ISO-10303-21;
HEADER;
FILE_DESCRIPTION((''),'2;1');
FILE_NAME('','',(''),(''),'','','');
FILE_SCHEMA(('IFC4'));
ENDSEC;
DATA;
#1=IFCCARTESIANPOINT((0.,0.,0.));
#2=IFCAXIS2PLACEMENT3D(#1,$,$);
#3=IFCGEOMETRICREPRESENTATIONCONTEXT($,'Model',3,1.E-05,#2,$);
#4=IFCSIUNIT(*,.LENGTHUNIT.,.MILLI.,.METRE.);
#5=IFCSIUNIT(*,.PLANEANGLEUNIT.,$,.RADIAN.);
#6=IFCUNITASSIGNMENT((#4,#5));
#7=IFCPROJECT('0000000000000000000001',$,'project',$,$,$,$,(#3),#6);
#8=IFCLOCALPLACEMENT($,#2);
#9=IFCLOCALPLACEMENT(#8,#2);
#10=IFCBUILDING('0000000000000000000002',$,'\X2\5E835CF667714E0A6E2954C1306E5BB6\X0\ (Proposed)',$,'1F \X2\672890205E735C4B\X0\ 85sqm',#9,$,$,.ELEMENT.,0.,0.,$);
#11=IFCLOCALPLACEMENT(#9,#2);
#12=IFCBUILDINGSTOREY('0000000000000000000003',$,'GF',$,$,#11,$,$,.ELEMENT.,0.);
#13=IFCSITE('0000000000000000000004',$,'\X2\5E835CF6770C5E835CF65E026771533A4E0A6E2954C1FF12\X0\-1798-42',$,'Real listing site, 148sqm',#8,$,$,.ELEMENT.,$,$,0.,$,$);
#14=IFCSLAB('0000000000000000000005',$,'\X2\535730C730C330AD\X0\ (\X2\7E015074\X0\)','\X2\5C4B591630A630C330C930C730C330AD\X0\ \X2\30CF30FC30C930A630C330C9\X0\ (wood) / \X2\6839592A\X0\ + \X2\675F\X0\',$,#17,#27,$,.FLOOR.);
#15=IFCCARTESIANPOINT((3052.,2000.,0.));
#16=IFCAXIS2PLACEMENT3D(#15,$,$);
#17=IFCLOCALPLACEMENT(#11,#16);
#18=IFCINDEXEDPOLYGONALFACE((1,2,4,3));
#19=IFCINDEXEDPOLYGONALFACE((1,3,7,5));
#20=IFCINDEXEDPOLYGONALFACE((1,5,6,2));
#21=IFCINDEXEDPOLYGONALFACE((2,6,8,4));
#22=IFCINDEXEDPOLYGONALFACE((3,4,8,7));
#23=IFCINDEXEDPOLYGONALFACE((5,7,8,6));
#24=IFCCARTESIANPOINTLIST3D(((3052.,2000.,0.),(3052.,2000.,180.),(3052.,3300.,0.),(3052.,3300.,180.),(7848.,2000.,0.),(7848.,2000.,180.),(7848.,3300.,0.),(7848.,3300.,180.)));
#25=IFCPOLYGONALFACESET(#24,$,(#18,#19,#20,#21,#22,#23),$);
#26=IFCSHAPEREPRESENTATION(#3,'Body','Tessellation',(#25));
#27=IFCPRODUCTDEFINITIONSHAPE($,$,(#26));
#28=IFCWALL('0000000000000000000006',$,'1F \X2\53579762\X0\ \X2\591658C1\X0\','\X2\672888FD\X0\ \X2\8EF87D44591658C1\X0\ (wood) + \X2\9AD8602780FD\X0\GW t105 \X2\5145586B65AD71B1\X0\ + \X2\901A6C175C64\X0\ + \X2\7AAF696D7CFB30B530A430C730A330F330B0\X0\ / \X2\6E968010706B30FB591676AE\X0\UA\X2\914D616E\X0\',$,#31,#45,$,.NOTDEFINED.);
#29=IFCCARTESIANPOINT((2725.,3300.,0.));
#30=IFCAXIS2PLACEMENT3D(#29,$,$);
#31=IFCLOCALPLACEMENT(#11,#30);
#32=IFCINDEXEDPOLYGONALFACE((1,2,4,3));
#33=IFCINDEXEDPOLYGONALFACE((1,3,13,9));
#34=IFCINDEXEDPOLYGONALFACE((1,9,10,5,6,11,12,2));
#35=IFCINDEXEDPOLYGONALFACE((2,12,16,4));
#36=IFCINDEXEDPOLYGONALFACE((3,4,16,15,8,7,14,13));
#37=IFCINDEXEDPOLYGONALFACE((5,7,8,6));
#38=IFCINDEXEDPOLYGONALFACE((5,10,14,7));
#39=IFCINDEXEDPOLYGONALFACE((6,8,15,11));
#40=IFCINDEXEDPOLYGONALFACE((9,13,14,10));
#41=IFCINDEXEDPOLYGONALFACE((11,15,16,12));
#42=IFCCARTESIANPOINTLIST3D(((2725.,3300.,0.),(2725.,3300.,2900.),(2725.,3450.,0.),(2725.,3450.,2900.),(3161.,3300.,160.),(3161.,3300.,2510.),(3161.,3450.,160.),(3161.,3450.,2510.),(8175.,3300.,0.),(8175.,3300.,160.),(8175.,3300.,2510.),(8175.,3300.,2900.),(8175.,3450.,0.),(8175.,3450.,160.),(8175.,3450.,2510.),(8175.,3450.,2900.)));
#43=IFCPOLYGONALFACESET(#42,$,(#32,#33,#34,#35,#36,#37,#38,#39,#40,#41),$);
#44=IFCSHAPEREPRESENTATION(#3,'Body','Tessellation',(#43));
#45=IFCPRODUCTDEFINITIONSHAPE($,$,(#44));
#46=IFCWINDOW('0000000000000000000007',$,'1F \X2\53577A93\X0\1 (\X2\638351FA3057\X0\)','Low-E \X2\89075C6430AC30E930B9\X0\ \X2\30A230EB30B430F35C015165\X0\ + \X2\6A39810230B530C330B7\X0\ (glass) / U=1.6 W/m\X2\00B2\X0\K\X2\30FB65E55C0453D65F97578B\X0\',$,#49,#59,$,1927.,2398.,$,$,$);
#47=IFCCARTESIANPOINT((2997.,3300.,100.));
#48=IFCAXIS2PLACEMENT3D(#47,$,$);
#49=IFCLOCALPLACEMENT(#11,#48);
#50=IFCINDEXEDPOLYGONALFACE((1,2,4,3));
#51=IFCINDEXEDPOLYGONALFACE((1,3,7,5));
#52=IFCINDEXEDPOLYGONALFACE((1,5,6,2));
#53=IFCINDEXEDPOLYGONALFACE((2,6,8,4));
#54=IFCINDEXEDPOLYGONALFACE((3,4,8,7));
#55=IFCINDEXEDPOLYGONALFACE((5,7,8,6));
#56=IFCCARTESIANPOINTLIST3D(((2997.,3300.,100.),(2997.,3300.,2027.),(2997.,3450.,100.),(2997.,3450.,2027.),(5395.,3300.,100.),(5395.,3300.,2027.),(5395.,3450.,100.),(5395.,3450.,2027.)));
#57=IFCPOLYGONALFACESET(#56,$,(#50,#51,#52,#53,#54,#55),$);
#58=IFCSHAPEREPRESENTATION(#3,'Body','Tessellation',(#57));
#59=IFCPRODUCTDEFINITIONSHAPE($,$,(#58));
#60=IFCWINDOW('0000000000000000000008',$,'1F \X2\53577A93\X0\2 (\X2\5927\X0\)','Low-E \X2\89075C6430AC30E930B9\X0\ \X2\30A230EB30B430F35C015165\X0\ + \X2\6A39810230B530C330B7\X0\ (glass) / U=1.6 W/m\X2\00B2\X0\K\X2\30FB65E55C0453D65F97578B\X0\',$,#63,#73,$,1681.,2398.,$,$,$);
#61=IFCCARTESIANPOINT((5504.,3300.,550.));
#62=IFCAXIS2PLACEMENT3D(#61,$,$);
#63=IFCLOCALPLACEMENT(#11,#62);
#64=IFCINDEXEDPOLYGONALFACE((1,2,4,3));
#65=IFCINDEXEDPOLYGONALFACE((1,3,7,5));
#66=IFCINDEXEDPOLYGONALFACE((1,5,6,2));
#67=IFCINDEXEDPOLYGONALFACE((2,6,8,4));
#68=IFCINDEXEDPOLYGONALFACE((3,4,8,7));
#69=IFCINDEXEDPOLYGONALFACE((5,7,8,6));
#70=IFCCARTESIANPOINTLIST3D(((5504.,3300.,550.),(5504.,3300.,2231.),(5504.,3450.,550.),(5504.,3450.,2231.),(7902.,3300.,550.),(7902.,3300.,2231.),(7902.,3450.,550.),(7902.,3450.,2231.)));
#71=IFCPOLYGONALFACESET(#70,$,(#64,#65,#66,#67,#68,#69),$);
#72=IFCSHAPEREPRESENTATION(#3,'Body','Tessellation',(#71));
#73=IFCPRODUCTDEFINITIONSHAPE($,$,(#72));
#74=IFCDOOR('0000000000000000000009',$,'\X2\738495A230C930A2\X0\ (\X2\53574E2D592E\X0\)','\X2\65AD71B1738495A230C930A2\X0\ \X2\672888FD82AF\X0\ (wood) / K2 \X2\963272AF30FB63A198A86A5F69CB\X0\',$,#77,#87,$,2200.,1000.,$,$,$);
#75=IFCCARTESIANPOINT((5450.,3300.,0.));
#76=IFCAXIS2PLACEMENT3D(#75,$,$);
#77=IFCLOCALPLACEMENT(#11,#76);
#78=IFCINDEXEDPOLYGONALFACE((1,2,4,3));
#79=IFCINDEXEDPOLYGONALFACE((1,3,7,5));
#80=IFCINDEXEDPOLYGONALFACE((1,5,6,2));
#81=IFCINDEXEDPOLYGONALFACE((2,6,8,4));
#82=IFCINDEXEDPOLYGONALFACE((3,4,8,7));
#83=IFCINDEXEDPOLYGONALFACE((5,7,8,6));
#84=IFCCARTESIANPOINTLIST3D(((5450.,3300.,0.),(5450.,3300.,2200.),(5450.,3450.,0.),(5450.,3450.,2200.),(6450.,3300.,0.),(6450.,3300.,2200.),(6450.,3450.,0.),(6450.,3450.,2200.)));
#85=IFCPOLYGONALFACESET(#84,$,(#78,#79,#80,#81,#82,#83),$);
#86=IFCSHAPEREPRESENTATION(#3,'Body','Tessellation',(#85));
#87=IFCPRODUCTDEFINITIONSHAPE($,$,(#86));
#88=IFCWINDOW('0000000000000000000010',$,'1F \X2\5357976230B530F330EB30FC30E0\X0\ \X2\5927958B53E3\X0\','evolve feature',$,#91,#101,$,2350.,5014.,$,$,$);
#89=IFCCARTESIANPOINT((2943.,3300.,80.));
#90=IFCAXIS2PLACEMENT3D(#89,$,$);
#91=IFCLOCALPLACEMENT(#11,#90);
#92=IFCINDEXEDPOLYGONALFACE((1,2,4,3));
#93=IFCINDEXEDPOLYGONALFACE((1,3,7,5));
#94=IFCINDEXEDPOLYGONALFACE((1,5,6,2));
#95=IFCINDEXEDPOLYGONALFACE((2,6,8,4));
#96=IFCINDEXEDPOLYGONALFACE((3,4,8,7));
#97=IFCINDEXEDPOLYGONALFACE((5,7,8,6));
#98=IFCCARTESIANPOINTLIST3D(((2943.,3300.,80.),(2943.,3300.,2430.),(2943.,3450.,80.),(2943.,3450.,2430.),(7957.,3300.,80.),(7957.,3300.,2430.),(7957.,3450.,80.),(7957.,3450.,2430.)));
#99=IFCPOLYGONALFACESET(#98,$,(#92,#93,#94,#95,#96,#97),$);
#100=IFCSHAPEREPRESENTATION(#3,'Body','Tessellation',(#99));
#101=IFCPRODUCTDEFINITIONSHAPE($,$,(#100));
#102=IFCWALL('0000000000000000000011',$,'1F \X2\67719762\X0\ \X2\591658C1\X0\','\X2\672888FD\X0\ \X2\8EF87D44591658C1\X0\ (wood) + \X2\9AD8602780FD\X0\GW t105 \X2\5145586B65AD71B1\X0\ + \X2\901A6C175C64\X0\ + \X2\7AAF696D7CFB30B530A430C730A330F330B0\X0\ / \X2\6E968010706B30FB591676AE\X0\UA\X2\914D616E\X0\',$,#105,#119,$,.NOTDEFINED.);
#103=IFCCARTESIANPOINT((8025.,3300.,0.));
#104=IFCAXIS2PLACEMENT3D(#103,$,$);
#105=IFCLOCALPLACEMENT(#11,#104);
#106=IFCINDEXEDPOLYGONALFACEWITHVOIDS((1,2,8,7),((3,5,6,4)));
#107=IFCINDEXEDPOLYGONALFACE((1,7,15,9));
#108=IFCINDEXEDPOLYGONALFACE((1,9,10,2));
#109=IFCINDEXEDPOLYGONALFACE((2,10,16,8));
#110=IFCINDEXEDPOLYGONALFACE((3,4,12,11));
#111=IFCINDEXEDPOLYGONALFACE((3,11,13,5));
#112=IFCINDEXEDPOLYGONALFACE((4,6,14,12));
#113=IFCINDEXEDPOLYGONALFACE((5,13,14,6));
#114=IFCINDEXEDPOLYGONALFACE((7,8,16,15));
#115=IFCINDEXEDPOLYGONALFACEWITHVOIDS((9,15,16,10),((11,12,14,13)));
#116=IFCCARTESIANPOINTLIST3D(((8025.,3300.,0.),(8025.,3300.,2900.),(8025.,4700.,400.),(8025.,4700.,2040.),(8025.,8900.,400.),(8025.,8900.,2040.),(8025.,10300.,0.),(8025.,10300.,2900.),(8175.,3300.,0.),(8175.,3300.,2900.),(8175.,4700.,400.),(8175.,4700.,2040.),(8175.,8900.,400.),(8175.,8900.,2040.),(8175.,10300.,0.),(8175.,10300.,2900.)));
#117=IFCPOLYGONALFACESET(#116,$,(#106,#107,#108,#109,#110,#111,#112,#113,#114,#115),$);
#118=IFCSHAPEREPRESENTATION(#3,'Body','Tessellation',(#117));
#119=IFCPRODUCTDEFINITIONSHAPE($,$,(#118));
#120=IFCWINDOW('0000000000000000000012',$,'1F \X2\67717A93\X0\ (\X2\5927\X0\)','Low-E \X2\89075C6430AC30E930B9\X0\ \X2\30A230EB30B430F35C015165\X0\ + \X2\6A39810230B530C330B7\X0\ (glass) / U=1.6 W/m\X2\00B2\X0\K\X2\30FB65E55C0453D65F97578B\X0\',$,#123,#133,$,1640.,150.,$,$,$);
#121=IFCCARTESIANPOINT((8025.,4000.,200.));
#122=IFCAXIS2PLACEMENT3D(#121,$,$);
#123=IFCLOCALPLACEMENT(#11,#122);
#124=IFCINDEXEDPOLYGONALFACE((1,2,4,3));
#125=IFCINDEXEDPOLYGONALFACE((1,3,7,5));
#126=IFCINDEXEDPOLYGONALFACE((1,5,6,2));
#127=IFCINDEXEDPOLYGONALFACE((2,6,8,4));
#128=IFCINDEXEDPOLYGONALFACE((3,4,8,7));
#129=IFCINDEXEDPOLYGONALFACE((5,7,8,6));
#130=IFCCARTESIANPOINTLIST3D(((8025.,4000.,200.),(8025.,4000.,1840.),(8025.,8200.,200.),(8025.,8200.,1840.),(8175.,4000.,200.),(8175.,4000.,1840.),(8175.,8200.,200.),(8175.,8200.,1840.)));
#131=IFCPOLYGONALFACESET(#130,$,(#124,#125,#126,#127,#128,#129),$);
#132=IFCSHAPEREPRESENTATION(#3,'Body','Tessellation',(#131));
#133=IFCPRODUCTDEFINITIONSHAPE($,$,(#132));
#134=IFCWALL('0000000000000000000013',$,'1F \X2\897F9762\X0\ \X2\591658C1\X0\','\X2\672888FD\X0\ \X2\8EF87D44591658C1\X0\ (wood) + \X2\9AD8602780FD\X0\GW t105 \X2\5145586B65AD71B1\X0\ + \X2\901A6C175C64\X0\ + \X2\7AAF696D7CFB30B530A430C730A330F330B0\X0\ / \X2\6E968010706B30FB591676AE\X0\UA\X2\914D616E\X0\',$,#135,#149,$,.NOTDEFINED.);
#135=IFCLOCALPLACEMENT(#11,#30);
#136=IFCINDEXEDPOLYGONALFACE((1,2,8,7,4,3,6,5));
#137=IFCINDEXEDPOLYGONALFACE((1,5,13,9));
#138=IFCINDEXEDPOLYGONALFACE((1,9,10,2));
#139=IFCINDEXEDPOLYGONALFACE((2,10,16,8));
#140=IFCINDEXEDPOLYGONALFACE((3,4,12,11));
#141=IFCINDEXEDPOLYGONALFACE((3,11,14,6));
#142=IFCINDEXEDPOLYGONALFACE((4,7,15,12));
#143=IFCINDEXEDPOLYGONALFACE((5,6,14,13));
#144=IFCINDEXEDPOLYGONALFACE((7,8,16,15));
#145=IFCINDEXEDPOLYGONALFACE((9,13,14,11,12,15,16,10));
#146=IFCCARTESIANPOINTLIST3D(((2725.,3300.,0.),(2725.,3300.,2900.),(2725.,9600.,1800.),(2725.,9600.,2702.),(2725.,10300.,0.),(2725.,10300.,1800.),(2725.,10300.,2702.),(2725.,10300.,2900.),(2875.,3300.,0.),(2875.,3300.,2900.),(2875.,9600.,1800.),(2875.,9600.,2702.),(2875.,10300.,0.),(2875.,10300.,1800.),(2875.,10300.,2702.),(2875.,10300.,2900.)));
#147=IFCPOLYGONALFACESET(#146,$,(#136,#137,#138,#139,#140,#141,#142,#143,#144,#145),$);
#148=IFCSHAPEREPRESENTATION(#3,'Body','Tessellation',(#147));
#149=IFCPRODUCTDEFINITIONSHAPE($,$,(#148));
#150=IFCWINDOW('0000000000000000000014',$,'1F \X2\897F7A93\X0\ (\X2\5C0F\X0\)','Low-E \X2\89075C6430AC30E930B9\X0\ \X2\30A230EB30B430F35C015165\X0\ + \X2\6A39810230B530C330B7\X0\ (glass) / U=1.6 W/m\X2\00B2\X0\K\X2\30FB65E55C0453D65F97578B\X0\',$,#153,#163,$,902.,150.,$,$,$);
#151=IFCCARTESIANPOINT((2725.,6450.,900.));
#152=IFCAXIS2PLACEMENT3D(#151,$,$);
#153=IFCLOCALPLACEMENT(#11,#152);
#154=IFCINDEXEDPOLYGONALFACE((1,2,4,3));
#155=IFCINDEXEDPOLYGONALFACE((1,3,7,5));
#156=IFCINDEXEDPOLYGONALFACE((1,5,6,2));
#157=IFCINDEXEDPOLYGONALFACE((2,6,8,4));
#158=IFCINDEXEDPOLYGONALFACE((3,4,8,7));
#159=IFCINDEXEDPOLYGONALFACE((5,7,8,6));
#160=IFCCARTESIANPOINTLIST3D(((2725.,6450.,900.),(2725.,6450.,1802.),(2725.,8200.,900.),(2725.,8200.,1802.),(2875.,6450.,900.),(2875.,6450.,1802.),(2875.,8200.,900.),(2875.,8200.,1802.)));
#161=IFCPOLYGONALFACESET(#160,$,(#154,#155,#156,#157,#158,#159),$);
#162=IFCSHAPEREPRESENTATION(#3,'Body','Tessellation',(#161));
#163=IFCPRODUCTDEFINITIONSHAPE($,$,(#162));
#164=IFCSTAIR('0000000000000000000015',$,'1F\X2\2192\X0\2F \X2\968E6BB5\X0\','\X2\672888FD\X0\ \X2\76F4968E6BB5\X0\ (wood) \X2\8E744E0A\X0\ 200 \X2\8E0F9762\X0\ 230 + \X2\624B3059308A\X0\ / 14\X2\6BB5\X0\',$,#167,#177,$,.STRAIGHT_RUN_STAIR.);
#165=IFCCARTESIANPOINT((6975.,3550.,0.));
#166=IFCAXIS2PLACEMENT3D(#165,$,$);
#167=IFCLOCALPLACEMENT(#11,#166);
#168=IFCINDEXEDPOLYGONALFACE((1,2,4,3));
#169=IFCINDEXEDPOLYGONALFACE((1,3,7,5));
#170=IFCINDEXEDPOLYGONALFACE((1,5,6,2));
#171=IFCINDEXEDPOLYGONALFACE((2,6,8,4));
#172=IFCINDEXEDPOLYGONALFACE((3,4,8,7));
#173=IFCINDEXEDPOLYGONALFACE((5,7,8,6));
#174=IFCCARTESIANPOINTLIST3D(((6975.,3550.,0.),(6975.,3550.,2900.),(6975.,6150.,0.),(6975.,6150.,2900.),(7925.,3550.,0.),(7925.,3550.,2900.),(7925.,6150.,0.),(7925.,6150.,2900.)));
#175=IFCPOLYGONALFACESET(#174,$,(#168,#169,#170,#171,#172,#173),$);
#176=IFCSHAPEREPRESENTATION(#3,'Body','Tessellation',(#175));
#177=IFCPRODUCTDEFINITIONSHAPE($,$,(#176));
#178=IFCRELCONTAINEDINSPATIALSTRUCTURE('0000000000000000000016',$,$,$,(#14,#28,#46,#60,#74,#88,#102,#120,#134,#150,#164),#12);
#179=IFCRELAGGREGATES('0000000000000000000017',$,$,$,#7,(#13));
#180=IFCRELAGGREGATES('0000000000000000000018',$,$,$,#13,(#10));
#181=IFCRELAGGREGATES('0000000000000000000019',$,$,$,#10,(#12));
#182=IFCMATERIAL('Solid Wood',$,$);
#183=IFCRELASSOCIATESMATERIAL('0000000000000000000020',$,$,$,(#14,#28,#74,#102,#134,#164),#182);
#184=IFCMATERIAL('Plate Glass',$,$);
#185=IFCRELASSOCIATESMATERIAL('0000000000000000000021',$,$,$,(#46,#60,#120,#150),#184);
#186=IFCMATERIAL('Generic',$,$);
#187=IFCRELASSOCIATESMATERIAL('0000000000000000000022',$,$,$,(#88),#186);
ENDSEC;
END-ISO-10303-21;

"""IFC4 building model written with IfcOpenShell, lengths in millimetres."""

from ifc_helpers import new_model, si_unit, frame, frame_2d, origin, place, context, project, spatial, rectangle, extrude, material, element, fill, save


model = new_model("IFC4")

# Units and contexts
model_context = context("Model", 3, precision=1e-05, world=origin())
ifc_project = project(units=[si_unit("LENGTHUNIT", "METRE", prefix="MILLI"), si_unit("PLANEANGLEUNIT", "RADIAN")], contexts=[model_context])

# Site, building, storey
site_placement = place(None, origin())
site = spatial("IfcSite", under=ifc_project, at=site_placement, Name="広島県広島市東区上温品２-1798-42", ObjectType="Real listing site, 148sqm", CompositionType="ELEMENT", RefElevation=0.0)
building_placement = place(site_placement, origin())
building = spatial("IfcBuilding", under=site, at=building_placement, Name="広島東上温品の家 (Proposed)", ObjectType="1F 木造平屋 85sqm", CompositionType="ELEMENT", ElevationOfRefHeight=0.0, ElevationOfTerrain=0.0)
storey_placement = place(building_placement, origin())
storey = spatial("IfcBuildingStorey", under=building, at=storey_placement, Name="GF", CompositionType="ELEMENT", Elevation=0.0)

# Slab
ifc_material_1 = material(Name="Solid Wood")
slab_1_placement = place(storey_placement, frame((3052.0, 2000.0, 0.0)))
element("IfcSlab", 1, at=slab_1_placement, inside=storey, material=ifc_material_1, Name="南デッキ (縁側)", Description="屋外ウッドデッキ ハードウッド (wood) / 根太 + 束", PredefinedType="FLOOR", context=model_context, shape_type="SweptSolid", body=[
    extrude(rectangle(XDim=4796.0, YDim=1300.0, at=frame_2d((2398.0, 650.0))), frame((3052.0, 2000.0, 0.0)), (0.0, 0.0, 1.0), 180.0),
])
ifc_material_2 = material(Name="Generic")

# Wall, openings, windows, door
wall_1_placement = place(storey_placement, frame((2725.0, 3300.0, 0.0)))
wall_1 = element("IfcWall", 2, at=wall_1_placement, inside=storey, material=ifc_material_1, Name="1F 南面 外壁", Description="木製 軸組外壁 (wood) + 高性能GW t105 充填断熱 + 通気層 + 窯業系サイディング / 準耐火・外皮UA配慮", PredefinedType="NOTDEFINED", context=model_context, shape_type="SweptSolid", body=[
    extrude(rectangle(XDim=5450.0, YDim=150.0, at=frame_2d((2725.0, 75.0))), frame((2725.0, 3300.0, 0.0)), (0.0, 0.0, 1.0), 2900.0),
])
opening_1_placement = place(storey_placement, frame((2997.0, 3300.0, 100.0)))
opening_1 = element("IfcOpeningElement", 3, at=opening_1_placement, cuts=wall_1, PredefinedType="NOTDEFINED", context=model_context, shape_type="SweptSolid", body=[
    extrude(rectangle(XDim=2398.0, YDim=150.0, at=frame_2d((1199.0, 75.0))), frame((2997.0, 3300.0, 100.0)), (0.0, 0.0, 1.0), 1927.0),
])
opening_2_placement = place(storey_placement, frame((5504.0, 3300.0, 550.0)))
opening_2 = element("IfcOpeningElement", 4, at=opening_2_placement, cuts=wall_1, PredefinedType="NOTDEFINED", context=model_context, shape_type="SweptSolid", body=[
    extrude(rectangle(XDim=2398.0, YDim=150.0, at=frame_2d((1199.0, 75.0))), frame((5504.0, 3300.0, 550.0)), (0.0, 0.0, 1.0), 1681.0),
])
opening_3_placement = place(storey_placement, frame((5450.0, 3300.0, 0.0)))
opening_3 = element("IfcOpeningElement", 5, at=opening_3_placement, cuts=wall_1, PredefinedType="NOTDEFINED", context=model_context, shape_type="SweptSolid", body=[
    extrude(rectangle(XDim=1000.0, YDim=150.0, at=frame_2d((500.0, 75.0))), frame((5450.0, 3300.0, 0.0)), (0.0, 0.0, 1.0), 2200.0),
])
opening_4_placement = place(storey_placement, frame((2943.0, 3300.0, 80.0)))
opening_4 = element("IfcOpeningElement", 6, at=opening_4_placement, cuts=wall_1, PredefinedType="NOTDEFINED", context=model_context, shape_type="SweptSolid", body=[
    extrude(rectangle(XDim=5014.0, YDim=150.0, at=frame_2d((2507.0, 75.0))), frame((2943.0, 3300.0, 80.0)), (0.0, 0.0, 1.0), 2350.0),
])
ifc_material_3 = material(Name="Plate Glass")
window_1_placement = place(storey_placement, frame((2997.0, 3300.0, 100.0)))
window_1 = element("IfcWindow", 7, at=window_1_placement, inside=storey, material=ifc_material_3, Name="1F 南窓1 (掃出し)", Description="Low-E 複層ガラス アルゴン封入 + 樹脂サッシ (glass) / U=1.6 W/m²K・日射取得型", OverallHeight=1927.0, OverallWidth=2398.0, context=model_context, shape_type="SweptSolid", body=[
    extrude(rectangle(XDim=2398.0, YDim=150.0, at=frame_2d((1199.0, 75.0))), frame((2997.0, 3300.0, 100.0)), (0.0, 0.0, 1.0), 1927.0),
])
fill(opening_1, window_1)
window_2_placement = place(storey_placement, frame((5504.0, 3300.0, 550.0)))
window_2 = element("IfcWindow", 8, at=window_2_placement, inside=storey, material=ifc_material_3, Name="1F 南窓2 (大)", Description="Low-E 複層ガラス アルゴン封入 + 樹脂サッシ (glass) / U=1.6 W/m²K・日射取得型", OverallHeight=1681.0, OverallWidth=2398.0, context=model_context, shape_type="SweptSolid", body=[
    extrude(rectangle(XDim=2398.0, YDim=150.0, at=frame_2d((1199.0, 75.0))), frame((5504.0, 3300.0, 550.0)), (0.0, 0.0, 1.0), 1681.0),
])
fill(opening_2, window_2)
door_placement = place(storey_placement, frame((5450.0, 3300.0, 0.0)))
door = element("IfcDoor", 9, at=door_placement, inside=storey, material=ifc_material_1, Name="玄関ドア (南中央)", Description="断熱玄関ドア 木製芯 (wood) / K2 防犯・採風機構", OverallHeight=2200.0, OverallWidth=1000.0, context=model_context, shape_type="SweptSolid", body=[
    extrude(rectangle(XDim=1000.0, YDim=150.0, at=frame_2d((500.0, 75.0))), frame((5450.0, 3300.0, 0.0)), (0.0, 0.0, 1.0), 2200.0),
])
fill(opening_3, door)
window_3_placement = place(storey_placement, frame((2943.0, 3300.0, 80.0)))
window_3 = element("IfcWindow", 10, at=window_3_placement, inside=storey, material=ifc_material_2, Name="1F 南面サンルーム 大開口", Description="evolve feature", OverallHeight=2350.0, OverallWidth=5014.0, context=model_context, shape_type="SweptSolid", body=[
    extrude(rectangle(XDim=5014.0, YDim=150.0, at=frame_2d((2507.0, 75.0))), frame((2943.0, 3300.0, 80.0)), (0.0, 0.0, 1.0), 2350.0),
])
fill(opening_4, window_3)

# Walls, openings, windows
wall_2_placement = place(storey_placement, frame((8025.0, 3300.0, 0.0)))
wall_2 = element("IfcWall", 11, at=wall_2_placement, inside=storey, material=ifc_material_1, Name="1F 東面 外壁", Description="木製 軸組外壁 (wood) + 高性能GW t105 充填断熱 + 通気層 + 窯業系サイディング / 準耐火・外皮UA配慮", PredefinedType="NOTDEFINED", context=model_context, shape_type="SweptSolid", body=[
    extrude(rectangle(XDim=150.0, YDim=7000.0, at=frame_2d((75.0, 3500.0))), frame((8025.0, 3300.0, 0.0)), (0.0, 0.0, 1.0), 2900.0),
])
opening_5_placement = place(storey_placement, frame((8025.0, 4000.0, 200.0)))
opening_5 = element("IfcOpeningElement", 12, at=opening_5_placement, cuts=wall_2, PredefinedType="NOTDEFINED", context=model_context, shape_type="SweptSolid", body=[
    extrude(rectangle(XDim=150.0, YDim=4200.0, at=frame_2d((75.0, 2100.0))), frame((8025.0, 4000.0, 200.0)), (0.0, 0.0, 1.0), 1640.0),
])
window_4_placement = place(storey_placement, frame((8025.0, 4000.0, 200.0)))
window_4 = element("IfcWindow", 13, at=window_4_placement, inside=storey, material=ifc_material_3, Name="1F 東窓 (大)", Description="Low-E 複層ガラス アルゴン封入 + 樹脂サッシ (glass) / U=1.6 W/m²K・日射取得型", OverallHeight=1640.0, OverallWidth=150.0, context=model_context, shape_type="SweptSolid", body=[
    extrude(rectangle(XDim=150.0, YDim=4200.0, at=frame_2d((75.0, 2100.0))), frame((8025.0, 4000.0, 200.0)), (0.0, 0.0, 1.0), 1640.0),
])
fill(opening_5, window_4)
wall_3_placement = place(storey_placement, frame((2725.0, 3300.0, 0.0)))
wall_3 = element("IfcWall", 14, at=wall_3_placement, inside=storey, material=ifc_material_1, Name="1F 西面 外壁", Description="木製 軸組外壁 (wood) + 高性能GW t105 充填断熱 + 通気層 + 窯業系サイディング / 準耐火・外皮UA配慮", PredefinedType="NOTDEFINED", context=model_context, shape_type="SweptSolid", body=[
    extrude(rectangle(XDim=150.0, YDim=7000.0, at=frame_2d((75.0, 3500.0))), frame((2725.0, 3300.0, 0.0)), (0.0, 0.0, 1.0), 2900.0),
])
opening_6_placement = place(storey_placement, frame((2725.0, 6450.0, 900.0)))
opening_6 = element("IfcOpeningElement", 15, at=opening_6_placement, cuts=wall_3, PredefinedType="NOTDEFINED", context=model_context, shape_type="SweptSolid", body=[
    extrude(rectangle(XDim=150.0, YDim=1750.0, at=frame_2d((75.0, 875.0))), frame((2725.0, 6450.0, 900.0)), (0.0, 0.0, 1.0), 902.0),
])
window_5_placement = place(storey_placement, frame((2725.0, 6450.0, 900.0)))
window_5 = element("IfcWindow", 16, at=window_5_placement, inside=storey, material=ifc_material_3, Name="1F 西窓 (小)", Description="Low-E 複層ガラス アルゴン封入 + 樹脂サッシ (glass) / U=1.6 W/m²K・日射取得型", OverallHeight=902.0, OverallWidth=150.0, context=model_context, shape_type="SweptSolid", body=[
    extrude(rectangle(XDim=150.0, YDim=1750.0, at=frame_2d((75.0, 875.0))), frame((2725.0, 6450.0, 900.0)), (0.0, 0.0, 1.0), 902.0),
])
fill(opening_6, window_5)

# Stair
stair_placement = place(storey_placement, frame((6975.0, 3550.0, 0.0)))
element("IfcStair", 17, at=stair_placement, inside=storey, material=ifc_material_1, Name="1F→2F 階段", Description="木製 直階段 (wood) 蹴上 200 踏面 230 + 手すり / 14段", PredefinedType="STRAIGHT_RUN_STAIR", context=model_context, shape_type="SweptSolid", body=[
    extrude(rectangle(XDim=950.0, YDim=2600.0, at=frame_2d((475.0, 1300.0))), frame((6975.0, 3550.0, 0.0)), (0.0, 0.0, 1.0), 2900.0),
])

save(model, "model.ifc")
